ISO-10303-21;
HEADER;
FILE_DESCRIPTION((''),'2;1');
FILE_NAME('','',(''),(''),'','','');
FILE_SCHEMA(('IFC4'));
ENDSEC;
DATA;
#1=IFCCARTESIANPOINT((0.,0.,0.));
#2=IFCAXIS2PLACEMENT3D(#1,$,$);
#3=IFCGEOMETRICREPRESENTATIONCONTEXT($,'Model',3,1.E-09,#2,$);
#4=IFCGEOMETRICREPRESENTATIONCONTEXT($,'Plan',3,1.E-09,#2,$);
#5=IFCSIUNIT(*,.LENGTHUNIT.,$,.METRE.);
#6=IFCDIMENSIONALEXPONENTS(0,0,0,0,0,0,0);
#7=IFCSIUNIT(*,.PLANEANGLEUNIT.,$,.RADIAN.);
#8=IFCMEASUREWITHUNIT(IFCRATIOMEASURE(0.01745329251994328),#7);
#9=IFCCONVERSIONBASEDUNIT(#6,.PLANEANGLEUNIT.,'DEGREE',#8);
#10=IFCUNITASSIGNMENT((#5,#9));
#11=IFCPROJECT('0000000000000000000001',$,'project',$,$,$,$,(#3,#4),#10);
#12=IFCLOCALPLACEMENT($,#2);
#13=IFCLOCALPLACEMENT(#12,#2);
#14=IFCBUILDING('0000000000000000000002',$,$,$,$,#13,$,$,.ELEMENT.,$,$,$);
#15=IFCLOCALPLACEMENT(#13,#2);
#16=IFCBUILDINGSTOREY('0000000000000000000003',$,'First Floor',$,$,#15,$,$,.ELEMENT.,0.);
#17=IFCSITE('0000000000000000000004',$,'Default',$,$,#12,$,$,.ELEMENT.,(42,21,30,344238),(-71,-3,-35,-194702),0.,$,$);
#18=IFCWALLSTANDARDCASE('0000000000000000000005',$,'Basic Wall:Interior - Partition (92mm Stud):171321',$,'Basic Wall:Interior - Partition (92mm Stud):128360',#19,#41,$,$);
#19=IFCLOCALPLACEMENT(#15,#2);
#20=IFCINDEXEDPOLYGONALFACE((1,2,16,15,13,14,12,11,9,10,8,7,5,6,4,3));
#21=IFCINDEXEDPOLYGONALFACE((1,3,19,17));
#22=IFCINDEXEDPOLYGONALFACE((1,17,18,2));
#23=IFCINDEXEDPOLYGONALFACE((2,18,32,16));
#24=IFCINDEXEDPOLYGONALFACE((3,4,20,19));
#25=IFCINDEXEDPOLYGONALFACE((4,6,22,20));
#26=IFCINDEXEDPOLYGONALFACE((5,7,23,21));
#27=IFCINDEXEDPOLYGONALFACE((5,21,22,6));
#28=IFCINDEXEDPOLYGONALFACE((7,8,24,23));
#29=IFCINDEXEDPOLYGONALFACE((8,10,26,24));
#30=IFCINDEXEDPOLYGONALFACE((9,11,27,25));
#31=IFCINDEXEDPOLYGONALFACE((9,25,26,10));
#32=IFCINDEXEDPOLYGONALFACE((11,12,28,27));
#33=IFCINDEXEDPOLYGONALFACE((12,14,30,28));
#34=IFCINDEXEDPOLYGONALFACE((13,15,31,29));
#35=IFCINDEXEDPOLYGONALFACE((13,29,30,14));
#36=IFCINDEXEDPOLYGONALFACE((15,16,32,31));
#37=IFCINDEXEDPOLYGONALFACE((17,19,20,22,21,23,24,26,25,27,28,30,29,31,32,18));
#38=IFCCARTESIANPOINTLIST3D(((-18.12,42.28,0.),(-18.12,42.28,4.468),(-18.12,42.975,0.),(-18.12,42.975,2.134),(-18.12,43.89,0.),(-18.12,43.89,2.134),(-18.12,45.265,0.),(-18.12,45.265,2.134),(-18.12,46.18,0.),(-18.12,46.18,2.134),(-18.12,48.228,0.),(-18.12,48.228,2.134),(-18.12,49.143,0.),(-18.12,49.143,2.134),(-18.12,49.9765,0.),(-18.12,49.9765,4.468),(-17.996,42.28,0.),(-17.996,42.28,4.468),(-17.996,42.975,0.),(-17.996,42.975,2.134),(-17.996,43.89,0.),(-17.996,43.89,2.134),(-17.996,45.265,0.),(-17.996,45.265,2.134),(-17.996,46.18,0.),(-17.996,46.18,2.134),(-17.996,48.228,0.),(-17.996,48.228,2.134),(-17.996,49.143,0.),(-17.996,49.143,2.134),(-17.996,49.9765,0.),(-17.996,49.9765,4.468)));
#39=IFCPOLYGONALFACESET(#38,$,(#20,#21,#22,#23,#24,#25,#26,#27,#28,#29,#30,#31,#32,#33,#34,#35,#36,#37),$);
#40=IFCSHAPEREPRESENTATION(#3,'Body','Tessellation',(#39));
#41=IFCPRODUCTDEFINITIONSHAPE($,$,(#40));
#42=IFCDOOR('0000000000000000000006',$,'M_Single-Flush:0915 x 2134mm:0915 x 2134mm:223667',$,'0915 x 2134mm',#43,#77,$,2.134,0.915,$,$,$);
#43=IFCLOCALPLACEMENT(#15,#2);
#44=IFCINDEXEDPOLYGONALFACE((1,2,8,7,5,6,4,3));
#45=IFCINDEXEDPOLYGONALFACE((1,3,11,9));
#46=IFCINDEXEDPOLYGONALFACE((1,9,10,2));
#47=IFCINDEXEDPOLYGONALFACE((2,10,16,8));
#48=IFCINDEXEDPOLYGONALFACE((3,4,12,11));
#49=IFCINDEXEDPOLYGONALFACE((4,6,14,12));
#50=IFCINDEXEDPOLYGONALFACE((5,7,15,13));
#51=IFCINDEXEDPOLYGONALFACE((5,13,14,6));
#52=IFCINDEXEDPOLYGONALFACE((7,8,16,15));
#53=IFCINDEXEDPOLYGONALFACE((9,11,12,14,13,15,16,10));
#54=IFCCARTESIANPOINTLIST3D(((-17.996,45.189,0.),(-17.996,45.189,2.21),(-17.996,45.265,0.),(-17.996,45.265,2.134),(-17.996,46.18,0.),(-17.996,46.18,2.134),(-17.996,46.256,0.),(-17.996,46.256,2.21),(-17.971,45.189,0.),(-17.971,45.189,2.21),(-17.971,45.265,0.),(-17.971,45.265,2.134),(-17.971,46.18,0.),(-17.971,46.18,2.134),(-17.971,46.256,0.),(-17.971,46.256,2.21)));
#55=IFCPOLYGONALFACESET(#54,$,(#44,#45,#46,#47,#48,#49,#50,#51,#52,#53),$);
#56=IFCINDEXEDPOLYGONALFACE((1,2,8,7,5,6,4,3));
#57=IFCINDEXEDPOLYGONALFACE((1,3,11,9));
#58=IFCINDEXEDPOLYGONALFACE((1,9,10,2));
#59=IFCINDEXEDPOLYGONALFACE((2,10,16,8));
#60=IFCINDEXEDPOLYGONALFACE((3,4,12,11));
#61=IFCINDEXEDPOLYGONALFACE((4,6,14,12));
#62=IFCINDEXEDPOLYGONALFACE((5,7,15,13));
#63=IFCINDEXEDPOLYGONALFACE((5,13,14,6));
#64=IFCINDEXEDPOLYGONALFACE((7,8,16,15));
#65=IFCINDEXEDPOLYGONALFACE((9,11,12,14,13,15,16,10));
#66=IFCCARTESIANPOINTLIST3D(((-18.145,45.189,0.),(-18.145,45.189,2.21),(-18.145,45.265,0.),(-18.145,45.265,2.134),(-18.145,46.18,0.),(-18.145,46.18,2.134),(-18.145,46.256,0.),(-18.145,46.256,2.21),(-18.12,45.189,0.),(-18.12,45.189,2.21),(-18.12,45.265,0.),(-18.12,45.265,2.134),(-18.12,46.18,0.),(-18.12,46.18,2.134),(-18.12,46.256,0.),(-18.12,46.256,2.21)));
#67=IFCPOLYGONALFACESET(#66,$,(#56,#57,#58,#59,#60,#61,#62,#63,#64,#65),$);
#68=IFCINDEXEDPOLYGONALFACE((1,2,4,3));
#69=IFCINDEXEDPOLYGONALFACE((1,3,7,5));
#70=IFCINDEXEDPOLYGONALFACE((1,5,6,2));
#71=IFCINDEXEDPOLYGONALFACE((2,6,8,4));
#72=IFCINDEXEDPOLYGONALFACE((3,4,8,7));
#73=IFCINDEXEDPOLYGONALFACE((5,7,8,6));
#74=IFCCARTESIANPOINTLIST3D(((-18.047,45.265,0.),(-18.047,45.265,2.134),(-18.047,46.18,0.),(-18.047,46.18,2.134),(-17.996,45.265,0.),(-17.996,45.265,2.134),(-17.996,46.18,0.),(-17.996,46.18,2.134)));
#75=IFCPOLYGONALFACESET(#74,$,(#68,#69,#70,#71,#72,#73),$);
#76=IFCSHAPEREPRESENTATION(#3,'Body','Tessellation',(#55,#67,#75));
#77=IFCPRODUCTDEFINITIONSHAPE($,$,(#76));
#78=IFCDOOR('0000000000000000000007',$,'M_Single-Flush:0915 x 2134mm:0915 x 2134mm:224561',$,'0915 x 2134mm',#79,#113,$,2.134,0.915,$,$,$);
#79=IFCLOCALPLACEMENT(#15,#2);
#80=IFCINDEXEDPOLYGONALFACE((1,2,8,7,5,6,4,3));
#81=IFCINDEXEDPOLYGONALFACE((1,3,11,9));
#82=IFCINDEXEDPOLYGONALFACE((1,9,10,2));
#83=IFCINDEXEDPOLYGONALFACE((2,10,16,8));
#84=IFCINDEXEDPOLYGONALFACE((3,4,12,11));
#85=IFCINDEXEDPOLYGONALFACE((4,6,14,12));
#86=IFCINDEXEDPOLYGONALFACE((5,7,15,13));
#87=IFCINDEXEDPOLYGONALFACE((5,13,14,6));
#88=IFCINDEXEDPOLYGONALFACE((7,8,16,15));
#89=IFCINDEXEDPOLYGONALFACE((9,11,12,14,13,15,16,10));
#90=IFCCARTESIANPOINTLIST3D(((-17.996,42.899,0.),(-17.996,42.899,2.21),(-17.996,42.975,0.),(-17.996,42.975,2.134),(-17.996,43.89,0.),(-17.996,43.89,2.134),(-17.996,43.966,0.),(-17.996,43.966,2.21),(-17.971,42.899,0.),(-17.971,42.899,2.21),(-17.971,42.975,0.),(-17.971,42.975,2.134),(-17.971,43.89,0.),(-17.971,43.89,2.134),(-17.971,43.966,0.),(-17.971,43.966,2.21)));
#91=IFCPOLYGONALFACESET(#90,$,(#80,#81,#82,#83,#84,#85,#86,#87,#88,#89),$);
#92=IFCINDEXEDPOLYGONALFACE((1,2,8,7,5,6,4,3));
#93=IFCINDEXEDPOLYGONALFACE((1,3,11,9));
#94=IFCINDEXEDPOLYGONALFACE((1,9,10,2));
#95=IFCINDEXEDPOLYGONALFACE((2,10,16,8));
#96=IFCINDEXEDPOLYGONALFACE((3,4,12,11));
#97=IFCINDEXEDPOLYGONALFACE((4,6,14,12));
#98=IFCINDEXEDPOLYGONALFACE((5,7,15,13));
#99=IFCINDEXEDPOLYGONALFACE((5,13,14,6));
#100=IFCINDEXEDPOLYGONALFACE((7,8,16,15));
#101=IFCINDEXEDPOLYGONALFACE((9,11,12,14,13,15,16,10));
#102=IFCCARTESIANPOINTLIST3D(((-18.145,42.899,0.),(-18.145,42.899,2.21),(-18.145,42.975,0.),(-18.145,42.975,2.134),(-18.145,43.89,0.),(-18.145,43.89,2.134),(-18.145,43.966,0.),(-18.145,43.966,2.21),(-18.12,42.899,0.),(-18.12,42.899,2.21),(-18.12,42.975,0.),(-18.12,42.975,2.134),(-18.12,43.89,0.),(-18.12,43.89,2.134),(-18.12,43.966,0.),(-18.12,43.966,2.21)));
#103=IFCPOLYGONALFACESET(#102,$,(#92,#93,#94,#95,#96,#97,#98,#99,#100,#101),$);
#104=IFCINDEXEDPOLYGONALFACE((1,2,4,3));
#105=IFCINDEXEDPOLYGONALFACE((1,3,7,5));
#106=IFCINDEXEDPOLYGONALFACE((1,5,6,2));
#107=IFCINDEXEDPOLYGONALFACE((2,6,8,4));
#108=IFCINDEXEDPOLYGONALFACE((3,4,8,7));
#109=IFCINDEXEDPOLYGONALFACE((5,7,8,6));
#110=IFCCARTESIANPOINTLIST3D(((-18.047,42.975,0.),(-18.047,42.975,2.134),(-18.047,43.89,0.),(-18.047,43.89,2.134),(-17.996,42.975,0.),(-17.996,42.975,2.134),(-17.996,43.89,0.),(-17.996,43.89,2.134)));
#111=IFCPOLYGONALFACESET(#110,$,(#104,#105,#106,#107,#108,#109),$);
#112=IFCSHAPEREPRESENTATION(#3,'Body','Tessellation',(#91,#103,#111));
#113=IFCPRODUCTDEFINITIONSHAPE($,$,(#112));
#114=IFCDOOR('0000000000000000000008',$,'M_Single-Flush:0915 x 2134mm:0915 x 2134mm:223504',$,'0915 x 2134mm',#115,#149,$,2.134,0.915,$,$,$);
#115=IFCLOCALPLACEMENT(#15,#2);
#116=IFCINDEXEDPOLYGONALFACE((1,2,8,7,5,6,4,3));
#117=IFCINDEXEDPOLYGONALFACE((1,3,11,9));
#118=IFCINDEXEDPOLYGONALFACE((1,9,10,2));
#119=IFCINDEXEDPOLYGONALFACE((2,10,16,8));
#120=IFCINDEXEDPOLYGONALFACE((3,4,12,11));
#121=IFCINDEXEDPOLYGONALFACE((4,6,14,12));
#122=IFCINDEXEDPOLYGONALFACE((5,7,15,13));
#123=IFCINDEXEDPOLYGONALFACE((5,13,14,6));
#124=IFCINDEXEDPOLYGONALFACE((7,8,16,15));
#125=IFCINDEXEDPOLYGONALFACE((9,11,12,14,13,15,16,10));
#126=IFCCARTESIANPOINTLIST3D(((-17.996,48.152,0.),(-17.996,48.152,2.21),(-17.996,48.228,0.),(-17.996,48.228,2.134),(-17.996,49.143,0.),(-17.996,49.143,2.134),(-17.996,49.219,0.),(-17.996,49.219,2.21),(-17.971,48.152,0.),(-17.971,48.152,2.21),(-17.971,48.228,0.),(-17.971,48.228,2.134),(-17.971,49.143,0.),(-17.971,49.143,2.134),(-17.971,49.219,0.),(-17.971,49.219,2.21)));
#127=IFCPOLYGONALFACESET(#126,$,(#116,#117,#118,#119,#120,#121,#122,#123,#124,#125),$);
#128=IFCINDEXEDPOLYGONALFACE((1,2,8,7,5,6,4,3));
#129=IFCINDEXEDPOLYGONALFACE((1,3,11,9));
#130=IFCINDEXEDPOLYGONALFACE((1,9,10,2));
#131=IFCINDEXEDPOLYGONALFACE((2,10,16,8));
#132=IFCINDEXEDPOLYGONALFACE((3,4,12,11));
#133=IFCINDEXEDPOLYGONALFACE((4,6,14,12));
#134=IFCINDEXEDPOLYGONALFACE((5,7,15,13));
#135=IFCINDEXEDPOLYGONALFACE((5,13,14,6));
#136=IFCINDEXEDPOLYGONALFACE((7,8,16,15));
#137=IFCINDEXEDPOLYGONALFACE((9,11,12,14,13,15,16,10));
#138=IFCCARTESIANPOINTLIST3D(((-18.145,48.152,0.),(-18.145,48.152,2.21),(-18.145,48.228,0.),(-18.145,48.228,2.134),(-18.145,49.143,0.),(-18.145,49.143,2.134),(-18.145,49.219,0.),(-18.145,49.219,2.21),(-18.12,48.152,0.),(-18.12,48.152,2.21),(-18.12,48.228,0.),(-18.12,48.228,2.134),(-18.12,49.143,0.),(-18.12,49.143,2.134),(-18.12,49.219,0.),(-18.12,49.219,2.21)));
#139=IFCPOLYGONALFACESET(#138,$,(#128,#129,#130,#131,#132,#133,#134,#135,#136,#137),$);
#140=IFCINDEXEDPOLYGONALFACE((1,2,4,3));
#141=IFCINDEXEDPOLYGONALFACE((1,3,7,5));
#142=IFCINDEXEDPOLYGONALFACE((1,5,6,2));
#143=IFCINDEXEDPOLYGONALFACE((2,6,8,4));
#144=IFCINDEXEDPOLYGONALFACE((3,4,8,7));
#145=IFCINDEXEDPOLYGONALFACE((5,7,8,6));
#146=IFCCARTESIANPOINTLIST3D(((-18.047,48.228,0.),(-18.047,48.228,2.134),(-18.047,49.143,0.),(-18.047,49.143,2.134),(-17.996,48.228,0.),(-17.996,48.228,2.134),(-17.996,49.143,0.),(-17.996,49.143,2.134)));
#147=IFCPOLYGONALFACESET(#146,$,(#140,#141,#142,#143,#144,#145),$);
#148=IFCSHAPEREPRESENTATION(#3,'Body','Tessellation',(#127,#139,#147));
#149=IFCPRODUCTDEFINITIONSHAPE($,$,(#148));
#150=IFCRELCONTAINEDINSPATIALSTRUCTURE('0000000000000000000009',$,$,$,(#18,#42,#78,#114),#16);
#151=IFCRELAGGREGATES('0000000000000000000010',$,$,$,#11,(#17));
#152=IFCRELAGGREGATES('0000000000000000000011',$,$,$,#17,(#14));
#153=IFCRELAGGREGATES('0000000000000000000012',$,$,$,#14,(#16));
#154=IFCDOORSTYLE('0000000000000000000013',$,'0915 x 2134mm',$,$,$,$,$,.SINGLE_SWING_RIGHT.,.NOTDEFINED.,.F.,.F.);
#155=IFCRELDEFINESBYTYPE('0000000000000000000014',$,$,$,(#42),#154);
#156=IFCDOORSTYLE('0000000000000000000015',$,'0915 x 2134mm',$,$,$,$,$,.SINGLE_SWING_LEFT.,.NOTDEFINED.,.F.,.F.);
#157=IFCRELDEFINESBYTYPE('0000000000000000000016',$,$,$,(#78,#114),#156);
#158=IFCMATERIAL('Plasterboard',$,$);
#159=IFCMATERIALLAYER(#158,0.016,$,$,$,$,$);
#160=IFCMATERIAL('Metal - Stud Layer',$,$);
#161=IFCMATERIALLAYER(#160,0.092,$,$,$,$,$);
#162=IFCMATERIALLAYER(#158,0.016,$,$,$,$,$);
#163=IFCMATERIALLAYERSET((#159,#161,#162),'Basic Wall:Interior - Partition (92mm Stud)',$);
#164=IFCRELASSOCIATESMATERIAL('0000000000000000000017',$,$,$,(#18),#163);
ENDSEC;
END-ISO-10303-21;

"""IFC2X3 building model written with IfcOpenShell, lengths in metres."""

from ifc_helpers import new_model, entity, si_unit, converted_unit, frame, frame_2d, origin, origin_2d_with_axis, place, context, project, spatial, polyline, rectangle, outline, extrude, source, transform, mapped, material, layer, layer_set, layer_usage, type_object, type_shapes, element, fill, save


model = new_model("IFC2X3")

# Units and contexts
model_context = context("Model", 3, precision=1e-09, world=origin())
plan_context = context("Plan", 3, precision=1e-09, world=origin())
ifc_project = project(units=[si_unit("LENGTHUNIT", "METRE"), converted_unit("PLANEANGLEUNIT", "DEGREE", entity("IfcRatioMeasure", 0.01745329251994328), si_unit("PLANEANGLEUNIT", "RADIAN"), dimensions=[0, 0, 0, 0, 0, 0, 0])], contexts=[model_context, plan_context])

# Site, building, storey
site_placement = place(None, origin())
site = spatial("IfcSite", under=ifc_project, at=site_placement, Name="Default", CompositionType="ELEMENT", RefLatitude=(42, 21, 30, 344238), RefLongitude=(-71, -3, -35, -194702), RefElevation=0.0)
building_placement = place(site_placement, origin())
building = spatial("IfcBuilding", under=site, at=building_placement, CompositionType="ELEMENT")
storey_placement = place(building_placement, origin())
storey = spatial("IfcBuildingStorey", under=building, at=storey_placement, Name="First Floor", CompositionType="ELEMENT", Elevation=0.0)

# Wall, openings, doors
ifc_material_1 = material(Name="Plasterboard")
ifc_layer_1 = layer(ifc_material_1, 0.016)
ifc_material_2 = material(Name="Metal - Stud Layer")
ifc_layer_2 = layer(ifc_material_2, 0.092)
ifc_layer_3 = layer(ifc_material_1, 0.016)
ifc_layer_set_1 = layer_set([ifc_layer_1, ifc_layer_2, ifc_layer_3], Name="Basic Wall:Interior - Partition (92mm Stud)")
ifc_layer_usage_1 = layer_usage(ifc_layer_set_1, "AXIS2", "NEGATIVE", 0.062)
wall_1_placement = place(storey_placement, frame((-18.058, 42.28, 0.0), z_axis=(0.0, 0.0, 1.0), x_axis=(0.0, 1.0, 0.0)))
wall_1 = element("IfcWallStandardCase", 1, at=wall_1_placement, inside=storey, material=ifc_layer_usage_1, Name="Basic Wall:Interior - Partition (92mm Stud):171321", ObjectType="Basic Wall:Interior - Partition (92mm Stud):128360", context=model_context, shape_type="SweptSolid", body=[
    extrude(rectangle(XDim=7.6965, YDim=0.124, at=frame_2d((3.8482, 0.0), x_axis=(-1.0, 0.0))), origin(), (0.0, 0.0, 1.0), 4.468),
])
opening_1_placement = place(wall_1_placement, frame((6.863, 0.062, 0.0)))
opening_1 = element("IfcOpeningElement", 2, at=opening_1_placement, cuts=wall_1, ObjectType="Opening", context=model_context, shape_type="SweptSolid", body=[
    extrude(rectangle(XDim=0.915, YDim=2.134, at=frame_2d((1.067, 0.4575), x_axis=(0.0, -1.0))), frame((0.0, 0.0, 0.0), z_axis=(0.0, -1.0, 0.0), x_axis=(0.0, 0.0, 1.0)), (0.0, 0.0, 1.0), 0.124),
])
opening_2_placement = place(wall_1_placement, frame((3.9, 0.062, 0.0)))
opening_2 = element("IfcOpeningElement", 3, at=opening_2_placement, cuts=wall_1, ObjectType="Opening", context=model_context, shape_type="SweptSolid", body=[
    extrude(rectangle(XDim=0.915, YDim=2.134, at=frame_2d((1.067, 0.4575), x_axis=(0.0, 1.0))), frame((0.0, 0.0, 0.0), z_axis=(0.0, -1.0, 0.0), x_axis=(0.0, 0.0, 1.0)), (0.0, 0.0, 1.0), 0.124),
])
opening_3_placement = place(wall_1_placement, frame((1.61, 0.062, 0.0)))
opening_3 = element("IfcOpeningElement", 4, at=opening_3_placement, cuts=wall_1, ObjectType="Opening", context=model_context, shape_type="SweptSolid", body=[
    extrude(rectangle(XDim=0.915, YDim=2.134, at=frame_2d((1.067, 0.4575), x_axis=(0.0, -1.0))), frame((0.0, 0.0, 0.0), z_axis=(0.0, -1.0, 0.0), x_axis=(0.0, 0.0, 1.0)), (0.0, 0.0, 1.0), 0.124),
])
door_style_1 = type_object("IfcDoorStyle", Name="0915 x 2134mm", ConstructionType="NOTDEFINED", OperationType="SINGLE_SWING_RIGHT", ParameterTakesPrecedence=False, Sizeable=False)
shared_shape_1 = source(origin(), model_context, "Body", "SweptSolid", [
    extrude(outline(polyline([(-0.5335, -1.124), (0.5335, -1.124), (0.5335, 1.086), (0.4575, 1.086), (0.4575, -1.048), (-0.4575, -1.048), (-0.4575, 1.086), (-0.5335, 1.086), (-0.5335, -1.124)])), frame((0.4575, 0.124, 1.086), z_axis=(0.0, 1.0, 0.0), x_axis=(1.0, 0.0, 0.0)), (0.0, 0.0, 1.0), 0.025),
    extrude(outline(polyline([(-1.124, -0.5335), (1.086, -0.5335), (1.086, -0.4575), (-1.048, -0.4575), (-1.048, 0.4575), (1.086, 0.4575), (1.086, 0.5335), (-1.124, 0.5335), (-1.124, -0.5335)])), frame((0.4575, -0.025, 1.086), z_axis=(0.0, 1.0, 0.0), x_axis=(0.0, 0.0, -1.0)), (0.0, 0.0, 1.0), 0.025),
    extrude(rectangle(XDim=0.051, YDim=0.915, at=origin_2d_with_axis()), frame((0.4575, 0.0985, 0.0), z_axis=(0.0, 0.0, 1.0), x_axis=(0.0, 1.0, 0.0)), (0.0, 0.0, 1.0), 2.134),
])
type_shapes(door_style_1, [shared_shape_1])
door_1_placement = place(opening_2_placement, frame((0.0, 0.0, 0.0), z_axis=(0.0, 0.0, 1.0), x_axis=(-1.0, 0.0, 0.0)))
door_1 = element("IfcDoor", 5, at=door_1_placement, inside=storey, type_object=door_style_1, Name="M_Single-Flush:0915 x 2134mm:0915 x 2134mm:223667", ObjectType="0915 x 2134mm", OverallHeight=2.134, OverallWidth=0.915, context=model_context, shape_type="MappedRepresentation", body=[
    mapped(shared_shape_1, transform((0.0, 0.0, 0.0), scale=1.0)),
])
fill(opening_2, door_1)
door_style_2 = type_object("IfcDoorStyle", Name="0915 x 2134mm", ConstructionType="NOTDEFINED", OperationType="SINGLE_SWING_LEFT", ParameterTakesPrecedence=False, Sizeable=False)
shared_shape_2 = source(origin(), model_context, "Body", "SweptSolid", [
    extrude(outline(polyline([(-0.5335, -1.124), (0.5335, -1.124), (0.5335, 1.086), (0.4575, 1.086), (0.4575, -1.048), (-0.4575, -1.048), (-0.4575, 1.086), (-0.5335, 1.086), (-0.5335, -1.124)])), frame((0.4575, 0.149, 1.086), z_axis=(0.0, -1.0, 0.0), x_axis=(-1.0, 0.0, 0.0)), (0.0, 0.0, 1.0), 0.025),
    extrude(outline(polyline([(-1.124, -0.5335), (1.086, -0.5335), (1.086, -0.4575), (-1.048, -0.4575), (-1.048, 0.4575), (1.086, 0.4575), (1.086, 0.5335), (-1.124, 0.5335), (-1.124, -0.5335)])), frame((0.4575, 0.0, 1.086), z_axis=(0.0, -1.0, 0.0), x_axis=(0.0, 0.0, -1.0)), (0.0, 0.0, 1.0), 0.025),
    extrude(rectangle(XDim=0.915, YDim=0.051, at=origin_2d_with_axis()), frame((0.4575, 0.0985, 0.0)), (0.0, 0.0, 1.0), 2.134),
])
type_shapes(door_style_2, [shared_shape_2])
door_2_placement = place(opening_3_placement, frame((0.0, 0.0, 0.0), z_axis=(0.0, 0.0, 1.0), x_axis=(-1.0, 0.0, 0.0)))
door_2 = element("IfcDoor", 6, at=door_2_placement, inside=storey, type_object=door_style_2, Name="M_Single-Flush:0915 x 2134mm:0915 x 2134mm:224561", ObjectType="0915 x 2134mm", OverallHeight=2.134, OverallWidth=0.915, context=model_context, shape_type="MappedRepresentation", body=[
    mapped(shared_shape_2, transform((0.0, 0.0, 0.0), scale=1.0)),
])
fill(opening_3, door_2)
door_3_placement = place(opening_1_placement, frame((0.0, 0.0, 0.0), z_axis=(0.0, 0.0, 1.0), x_axis=(-1.0, 0.0, 0.0)))
door_3 = element("IfcDoor", 7, at=door_3_placement, inside=storey, type_object=door_style_2, Name="M_Single-Flush:0915 x 2134mm:0915 x 2134mm:223504", ObjectType="0915 x 2134mm", OverallHeight=2.134, OverallWidth=0.915, context=model_context, shape_type="MappedRepresentation", body=[
    mapped(shared_shape_2, transform((0.0, 0.0, 0.0), scale=1.0)),
])
fill(opening_1, door_3)

save(model, "model.ifc")
